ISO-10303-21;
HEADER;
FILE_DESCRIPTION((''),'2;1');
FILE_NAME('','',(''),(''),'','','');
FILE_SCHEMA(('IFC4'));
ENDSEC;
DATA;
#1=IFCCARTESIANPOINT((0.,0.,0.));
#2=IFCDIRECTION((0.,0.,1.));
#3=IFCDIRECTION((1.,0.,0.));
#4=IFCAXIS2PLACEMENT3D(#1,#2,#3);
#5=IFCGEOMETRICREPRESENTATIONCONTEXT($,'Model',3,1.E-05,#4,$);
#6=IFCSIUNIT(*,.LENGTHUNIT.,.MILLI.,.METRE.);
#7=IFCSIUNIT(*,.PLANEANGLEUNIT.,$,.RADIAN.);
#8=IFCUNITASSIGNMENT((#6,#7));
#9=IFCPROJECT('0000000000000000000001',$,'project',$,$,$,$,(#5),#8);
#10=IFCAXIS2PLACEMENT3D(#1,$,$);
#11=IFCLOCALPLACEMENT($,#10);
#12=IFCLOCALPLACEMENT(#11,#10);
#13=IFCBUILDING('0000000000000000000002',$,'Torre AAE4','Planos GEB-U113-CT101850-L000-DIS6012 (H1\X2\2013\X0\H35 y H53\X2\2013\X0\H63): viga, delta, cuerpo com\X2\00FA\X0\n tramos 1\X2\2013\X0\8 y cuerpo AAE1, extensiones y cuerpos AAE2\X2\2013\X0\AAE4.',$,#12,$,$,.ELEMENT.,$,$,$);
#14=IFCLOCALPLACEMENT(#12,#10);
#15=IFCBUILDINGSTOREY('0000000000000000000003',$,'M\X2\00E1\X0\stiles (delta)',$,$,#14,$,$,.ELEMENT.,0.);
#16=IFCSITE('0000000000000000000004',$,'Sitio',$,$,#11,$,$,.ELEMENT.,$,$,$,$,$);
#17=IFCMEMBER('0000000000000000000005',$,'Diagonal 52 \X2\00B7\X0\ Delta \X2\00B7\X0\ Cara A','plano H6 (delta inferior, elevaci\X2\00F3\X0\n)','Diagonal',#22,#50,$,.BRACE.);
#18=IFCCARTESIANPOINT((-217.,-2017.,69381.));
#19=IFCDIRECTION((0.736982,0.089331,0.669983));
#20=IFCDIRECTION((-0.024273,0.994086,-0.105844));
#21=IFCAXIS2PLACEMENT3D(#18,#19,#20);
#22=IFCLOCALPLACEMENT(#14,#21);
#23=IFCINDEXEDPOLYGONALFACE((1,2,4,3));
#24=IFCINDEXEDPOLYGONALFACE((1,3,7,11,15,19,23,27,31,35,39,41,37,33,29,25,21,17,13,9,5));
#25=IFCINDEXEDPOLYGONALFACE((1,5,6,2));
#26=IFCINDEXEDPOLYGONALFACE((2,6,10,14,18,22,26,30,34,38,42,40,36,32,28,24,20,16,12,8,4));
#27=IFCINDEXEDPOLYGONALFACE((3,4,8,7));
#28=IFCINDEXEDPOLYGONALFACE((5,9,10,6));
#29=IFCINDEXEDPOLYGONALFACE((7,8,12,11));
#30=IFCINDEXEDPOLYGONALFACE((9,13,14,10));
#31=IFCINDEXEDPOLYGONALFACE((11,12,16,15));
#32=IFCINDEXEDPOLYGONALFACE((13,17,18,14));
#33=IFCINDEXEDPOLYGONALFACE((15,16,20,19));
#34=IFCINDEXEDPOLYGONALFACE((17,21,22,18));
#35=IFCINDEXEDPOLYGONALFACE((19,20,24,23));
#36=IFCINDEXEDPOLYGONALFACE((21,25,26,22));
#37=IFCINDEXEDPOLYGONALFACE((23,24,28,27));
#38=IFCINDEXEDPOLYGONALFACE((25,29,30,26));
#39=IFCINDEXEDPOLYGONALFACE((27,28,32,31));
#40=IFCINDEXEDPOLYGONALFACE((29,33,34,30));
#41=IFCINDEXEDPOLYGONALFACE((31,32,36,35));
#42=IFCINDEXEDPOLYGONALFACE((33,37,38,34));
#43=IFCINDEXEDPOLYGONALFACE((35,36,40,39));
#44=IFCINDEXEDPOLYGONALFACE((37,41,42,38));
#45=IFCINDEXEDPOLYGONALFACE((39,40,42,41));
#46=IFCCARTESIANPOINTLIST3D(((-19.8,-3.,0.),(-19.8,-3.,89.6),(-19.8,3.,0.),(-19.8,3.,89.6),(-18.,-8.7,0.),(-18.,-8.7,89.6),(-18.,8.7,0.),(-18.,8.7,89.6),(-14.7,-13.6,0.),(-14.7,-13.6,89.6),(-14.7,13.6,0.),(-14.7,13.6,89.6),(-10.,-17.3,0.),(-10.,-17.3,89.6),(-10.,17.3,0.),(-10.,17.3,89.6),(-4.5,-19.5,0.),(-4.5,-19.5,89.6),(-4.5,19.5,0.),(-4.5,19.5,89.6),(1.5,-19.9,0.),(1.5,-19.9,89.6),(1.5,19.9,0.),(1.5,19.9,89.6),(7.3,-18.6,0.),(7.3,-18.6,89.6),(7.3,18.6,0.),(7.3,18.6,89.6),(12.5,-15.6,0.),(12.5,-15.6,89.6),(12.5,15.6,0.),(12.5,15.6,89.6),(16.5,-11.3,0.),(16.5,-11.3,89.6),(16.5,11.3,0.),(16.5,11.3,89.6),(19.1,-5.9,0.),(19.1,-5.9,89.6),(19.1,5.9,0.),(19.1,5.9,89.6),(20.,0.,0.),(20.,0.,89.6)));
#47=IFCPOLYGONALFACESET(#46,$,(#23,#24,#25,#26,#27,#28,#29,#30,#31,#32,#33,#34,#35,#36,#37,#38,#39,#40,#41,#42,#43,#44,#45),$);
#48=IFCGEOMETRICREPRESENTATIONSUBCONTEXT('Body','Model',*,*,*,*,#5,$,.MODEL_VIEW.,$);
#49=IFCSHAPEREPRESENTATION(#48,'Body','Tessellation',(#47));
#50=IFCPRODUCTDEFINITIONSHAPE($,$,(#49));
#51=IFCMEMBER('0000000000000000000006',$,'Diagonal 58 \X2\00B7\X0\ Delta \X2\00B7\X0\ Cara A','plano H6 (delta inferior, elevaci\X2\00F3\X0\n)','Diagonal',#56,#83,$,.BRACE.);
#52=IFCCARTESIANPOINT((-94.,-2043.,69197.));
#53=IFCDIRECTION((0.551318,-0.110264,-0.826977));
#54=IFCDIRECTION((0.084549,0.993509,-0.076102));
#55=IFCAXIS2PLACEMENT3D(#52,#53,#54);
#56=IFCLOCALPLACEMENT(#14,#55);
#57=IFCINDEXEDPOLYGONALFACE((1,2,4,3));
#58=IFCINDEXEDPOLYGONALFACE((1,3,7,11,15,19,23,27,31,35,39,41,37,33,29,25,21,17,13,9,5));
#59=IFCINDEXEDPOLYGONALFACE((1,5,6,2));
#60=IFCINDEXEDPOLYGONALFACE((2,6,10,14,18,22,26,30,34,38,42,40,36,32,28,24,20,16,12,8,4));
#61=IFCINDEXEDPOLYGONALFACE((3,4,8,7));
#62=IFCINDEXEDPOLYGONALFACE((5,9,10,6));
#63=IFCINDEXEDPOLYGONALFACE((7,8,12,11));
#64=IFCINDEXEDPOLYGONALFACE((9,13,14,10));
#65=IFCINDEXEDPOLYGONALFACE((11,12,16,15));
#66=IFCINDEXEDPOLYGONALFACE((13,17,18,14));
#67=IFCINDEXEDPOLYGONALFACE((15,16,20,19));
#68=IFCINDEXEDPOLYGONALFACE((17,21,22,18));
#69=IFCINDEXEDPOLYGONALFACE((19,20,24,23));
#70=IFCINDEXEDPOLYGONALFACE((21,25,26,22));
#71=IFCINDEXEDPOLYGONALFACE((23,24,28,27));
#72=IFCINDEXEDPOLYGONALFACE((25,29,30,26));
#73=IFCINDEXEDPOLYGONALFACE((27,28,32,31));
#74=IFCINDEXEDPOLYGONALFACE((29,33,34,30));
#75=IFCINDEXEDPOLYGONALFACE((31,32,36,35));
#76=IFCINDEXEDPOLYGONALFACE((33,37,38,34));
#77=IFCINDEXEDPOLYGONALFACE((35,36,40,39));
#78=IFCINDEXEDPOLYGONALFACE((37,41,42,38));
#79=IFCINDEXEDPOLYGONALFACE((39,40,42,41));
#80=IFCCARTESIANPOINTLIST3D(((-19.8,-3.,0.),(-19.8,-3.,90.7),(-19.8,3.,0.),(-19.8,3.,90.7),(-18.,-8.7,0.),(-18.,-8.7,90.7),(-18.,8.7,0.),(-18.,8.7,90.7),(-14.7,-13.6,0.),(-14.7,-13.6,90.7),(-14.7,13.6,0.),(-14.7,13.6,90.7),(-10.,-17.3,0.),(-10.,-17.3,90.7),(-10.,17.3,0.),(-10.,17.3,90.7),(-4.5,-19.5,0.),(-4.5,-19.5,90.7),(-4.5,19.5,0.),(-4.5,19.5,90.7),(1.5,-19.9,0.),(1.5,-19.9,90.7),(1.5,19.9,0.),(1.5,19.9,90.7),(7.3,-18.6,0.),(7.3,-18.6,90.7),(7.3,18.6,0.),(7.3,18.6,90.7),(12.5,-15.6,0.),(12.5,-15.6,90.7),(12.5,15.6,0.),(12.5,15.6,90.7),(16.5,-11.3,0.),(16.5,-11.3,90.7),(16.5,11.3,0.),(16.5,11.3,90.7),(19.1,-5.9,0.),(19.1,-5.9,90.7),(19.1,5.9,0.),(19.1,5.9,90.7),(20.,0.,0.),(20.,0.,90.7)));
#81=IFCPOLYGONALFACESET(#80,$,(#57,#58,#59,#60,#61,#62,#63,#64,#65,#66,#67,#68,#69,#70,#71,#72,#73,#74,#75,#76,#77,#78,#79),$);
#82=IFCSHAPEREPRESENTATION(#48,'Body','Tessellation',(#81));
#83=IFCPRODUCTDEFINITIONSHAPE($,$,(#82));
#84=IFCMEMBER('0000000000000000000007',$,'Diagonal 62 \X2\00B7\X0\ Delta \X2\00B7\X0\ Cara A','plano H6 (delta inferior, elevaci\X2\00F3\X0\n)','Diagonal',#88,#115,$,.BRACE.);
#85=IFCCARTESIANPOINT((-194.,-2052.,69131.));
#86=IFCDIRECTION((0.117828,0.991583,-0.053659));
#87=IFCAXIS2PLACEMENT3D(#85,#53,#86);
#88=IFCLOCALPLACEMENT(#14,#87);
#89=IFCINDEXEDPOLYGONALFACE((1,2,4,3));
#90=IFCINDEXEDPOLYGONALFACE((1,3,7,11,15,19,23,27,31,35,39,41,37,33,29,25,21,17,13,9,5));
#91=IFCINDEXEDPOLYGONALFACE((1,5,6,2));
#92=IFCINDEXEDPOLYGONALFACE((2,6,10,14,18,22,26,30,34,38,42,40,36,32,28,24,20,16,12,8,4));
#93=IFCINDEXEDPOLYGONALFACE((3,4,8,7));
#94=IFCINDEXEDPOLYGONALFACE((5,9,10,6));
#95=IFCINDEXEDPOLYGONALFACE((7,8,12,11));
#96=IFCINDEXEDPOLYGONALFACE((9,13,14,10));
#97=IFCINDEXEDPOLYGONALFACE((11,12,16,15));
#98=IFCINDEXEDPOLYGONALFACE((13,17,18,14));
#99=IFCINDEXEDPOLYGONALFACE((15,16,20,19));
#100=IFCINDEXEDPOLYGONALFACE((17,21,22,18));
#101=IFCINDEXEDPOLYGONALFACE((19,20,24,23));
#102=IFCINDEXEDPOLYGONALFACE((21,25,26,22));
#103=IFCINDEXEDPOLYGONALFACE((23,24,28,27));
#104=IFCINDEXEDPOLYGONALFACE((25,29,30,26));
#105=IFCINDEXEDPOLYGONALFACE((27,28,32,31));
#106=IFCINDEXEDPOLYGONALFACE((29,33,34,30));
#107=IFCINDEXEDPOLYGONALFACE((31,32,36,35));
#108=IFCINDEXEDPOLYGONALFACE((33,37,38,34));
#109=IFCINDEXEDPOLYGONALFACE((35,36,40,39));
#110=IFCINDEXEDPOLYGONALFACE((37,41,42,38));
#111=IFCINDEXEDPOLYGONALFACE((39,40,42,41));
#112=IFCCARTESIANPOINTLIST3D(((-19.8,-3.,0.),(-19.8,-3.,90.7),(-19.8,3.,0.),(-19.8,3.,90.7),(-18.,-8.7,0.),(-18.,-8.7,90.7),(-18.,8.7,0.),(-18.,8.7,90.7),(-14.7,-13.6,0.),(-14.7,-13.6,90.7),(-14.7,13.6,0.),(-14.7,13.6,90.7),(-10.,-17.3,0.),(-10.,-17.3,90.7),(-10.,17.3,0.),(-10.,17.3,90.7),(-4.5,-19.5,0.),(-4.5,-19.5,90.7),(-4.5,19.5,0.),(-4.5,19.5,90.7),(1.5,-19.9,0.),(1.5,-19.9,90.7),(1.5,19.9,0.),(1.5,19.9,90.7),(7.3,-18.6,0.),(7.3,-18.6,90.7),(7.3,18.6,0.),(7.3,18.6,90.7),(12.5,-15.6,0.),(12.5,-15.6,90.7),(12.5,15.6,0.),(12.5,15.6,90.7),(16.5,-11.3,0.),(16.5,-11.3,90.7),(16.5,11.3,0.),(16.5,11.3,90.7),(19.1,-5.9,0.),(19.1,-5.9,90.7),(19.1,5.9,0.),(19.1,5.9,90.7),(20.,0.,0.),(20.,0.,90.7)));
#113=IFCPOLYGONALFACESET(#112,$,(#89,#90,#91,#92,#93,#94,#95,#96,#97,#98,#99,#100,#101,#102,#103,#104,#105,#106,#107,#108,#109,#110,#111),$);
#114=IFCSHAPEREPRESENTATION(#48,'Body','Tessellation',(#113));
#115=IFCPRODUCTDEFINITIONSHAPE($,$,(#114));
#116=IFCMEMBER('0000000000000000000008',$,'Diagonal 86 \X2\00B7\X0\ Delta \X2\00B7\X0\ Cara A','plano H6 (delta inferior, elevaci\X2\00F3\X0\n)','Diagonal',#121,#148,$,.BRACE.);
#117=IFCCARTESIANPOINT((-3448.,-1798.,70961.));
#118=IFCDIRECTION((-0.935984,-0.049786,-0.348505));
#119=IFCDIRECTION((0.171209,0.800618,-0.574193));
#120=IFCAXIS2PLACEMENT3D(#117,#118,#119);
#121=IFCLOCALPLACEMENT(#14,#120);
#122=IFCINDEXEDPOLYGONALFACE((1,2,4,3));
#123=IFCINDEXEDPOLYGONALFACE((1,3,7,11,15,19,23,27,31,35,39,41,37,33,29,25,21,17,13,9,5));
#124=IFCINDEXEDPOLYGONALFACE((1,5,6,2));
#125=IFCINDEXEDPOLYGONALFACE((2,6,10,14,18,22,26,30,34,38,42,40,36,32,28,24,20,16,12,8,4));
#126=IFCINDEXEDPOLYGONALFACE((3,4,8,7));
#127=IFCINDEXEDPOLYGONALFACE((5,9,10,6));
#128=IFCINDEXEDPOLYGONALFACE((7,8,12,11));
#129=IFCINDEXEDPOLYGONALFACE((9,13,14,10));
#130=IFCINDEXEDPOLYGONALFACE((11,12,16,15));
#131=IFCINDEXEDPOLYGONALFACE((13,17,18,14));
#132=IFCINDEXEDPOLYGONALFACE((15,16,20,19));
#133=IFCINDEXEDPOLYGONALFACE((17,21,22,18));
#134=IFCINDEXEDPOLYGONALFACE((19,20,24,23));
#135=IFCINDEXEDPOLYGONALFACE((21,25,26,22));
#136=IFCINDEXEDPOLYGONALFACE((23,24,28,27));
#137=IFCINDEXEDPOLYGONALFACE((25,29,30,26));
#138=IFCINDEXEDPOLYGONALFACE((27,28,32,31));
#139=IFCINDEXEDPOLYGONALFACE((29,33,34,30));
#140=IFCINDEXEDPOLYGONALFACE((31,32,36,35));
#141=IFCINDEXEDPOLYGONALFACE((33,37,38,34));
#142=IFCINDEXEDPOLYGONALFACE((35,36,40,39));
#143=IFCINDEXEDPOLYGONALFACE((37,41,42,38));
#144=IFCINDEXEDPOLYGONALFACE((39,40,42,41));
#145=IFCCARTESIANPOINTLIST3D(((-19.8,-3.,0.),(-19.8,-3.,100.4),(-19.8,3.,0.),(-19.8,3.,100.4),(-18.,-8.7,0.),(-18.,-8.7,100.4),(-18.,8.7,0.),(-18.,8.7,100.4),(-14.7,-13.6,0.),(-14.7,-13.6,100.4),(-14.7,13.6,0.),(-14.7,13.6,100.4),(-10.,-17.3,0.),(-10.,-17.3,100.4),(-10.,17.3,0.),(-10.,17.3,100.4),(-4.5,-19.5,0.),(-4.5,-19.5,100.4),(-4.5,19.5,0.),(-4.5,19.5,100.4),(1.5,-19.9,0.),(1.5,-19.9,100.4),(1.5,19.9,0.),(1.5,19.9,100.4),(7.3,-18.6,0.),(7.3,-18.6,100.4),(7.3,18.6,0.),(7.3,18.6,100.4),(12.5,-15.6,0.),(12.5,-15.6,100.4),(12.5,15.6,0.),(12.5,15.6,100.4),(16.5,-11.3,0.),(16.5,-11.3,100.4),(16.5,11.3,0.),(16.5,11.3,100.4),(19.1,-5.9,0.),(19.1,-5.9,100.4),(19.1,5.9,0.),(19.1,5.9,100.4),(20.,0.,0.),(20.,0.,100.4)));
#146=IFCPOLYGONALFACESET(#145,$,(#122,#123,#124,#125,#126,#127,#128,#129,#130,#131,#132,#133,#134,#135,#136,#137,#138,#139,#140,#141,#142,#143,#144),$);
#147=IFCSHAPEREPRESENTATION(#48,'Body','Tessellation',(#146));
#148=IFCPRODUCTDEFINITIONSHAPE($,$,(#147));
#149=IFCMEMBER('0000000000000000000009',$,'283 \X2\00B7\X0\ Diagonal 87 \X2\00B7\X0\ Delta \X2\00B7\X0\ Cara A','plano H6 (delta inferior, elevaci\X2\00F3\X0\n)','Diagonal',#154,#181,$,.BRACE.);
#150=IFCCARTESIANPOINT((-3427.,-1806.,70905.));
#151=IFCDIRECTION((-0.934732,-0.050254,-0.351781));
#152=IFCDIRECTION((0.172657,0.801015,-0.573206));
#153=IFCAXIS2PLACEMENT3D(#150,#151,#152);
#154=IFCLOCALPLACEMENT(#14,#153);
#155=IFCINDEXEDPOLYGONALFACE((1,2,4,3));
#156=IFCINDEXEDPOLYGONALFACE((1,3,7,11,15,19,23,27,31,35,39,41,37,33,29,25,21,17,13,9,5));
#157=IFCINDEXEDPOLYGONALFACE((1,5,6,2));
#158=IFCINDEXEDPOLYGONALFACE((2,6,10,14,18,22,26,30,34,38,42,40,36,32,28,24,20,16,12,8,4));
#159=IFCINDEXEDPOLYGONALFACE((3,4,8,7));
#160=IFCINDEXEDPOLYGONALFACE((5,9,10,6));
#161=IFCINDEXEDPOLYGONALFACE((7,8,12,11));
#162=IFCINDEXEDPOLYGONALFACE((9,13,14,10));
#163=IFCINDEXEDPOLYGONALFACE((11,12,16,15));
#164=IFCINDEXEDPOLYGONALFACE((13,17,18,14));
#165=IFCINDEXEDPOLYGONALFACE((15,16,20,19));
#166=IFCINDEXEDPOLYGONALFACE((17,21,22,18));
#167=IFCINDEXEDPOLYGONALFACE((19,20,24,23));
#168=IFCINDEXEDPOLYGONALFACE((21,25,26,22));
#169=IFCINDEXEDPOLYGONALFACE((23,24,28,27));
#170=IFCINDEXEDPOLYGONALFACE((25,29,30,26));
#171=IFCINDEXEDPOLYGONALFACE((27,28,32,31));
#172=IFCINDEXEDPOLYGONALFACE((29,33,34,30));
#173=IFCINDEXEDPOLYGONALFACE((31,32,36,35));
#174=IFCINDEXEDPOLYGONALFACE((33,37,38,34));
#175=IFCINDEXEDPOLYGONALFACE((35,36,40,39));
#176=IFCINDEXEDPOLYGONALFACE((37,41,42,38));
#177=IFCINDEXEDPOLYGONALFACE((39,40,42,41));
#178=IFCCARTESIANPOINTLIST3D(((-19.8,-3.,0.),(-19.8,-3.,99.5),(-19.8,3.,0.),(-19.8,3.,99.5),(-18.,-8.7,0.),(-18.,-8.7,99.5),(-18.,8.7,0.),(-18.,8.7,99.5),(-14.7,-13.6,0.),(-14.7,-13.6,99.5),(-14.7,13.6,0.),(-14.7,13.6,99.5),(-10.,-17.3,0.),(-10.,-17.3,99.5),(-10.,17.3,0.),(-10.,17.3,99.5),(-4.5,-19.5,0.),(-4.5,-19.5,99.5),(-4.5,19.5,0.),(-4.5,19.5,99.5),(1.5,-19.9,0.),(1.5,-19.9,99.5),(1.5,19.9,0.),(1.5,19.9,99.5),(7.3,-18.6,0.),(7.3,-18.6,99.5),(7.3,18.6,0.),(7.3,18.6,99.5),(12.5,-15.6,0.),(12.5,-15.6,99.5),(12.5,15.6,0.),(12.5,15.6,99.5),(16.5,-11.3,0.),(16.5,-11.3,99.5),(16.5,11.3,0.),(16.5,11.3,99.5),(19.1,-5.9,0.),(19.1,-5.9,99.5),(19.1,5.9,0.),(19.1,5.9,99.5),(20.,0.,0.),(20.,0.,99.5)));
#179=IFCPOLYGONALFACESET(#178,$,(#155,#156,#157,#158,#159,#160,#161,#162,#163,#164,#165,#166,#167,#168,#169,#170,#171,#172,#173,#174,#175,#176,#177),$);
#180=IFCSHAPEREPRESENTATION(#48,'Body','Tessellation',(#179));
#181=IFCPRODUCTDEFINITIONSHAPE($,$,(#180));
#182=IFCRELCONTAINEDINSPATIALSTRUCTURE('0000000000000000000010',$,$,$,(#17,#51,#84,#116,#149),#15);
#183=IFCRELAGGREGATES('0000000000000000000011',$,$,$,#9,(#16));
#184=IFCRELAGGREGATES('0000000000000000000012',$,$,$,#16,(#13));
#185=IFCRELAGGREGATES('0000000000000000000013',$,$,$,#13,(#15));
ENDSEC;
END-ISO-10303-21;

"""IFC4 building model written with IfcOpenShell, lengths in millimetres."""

from ifc_helpers import new_model, si_unit, frame, origin, origin_with_axes, place, context, subcontext, project, spatial, circle, extrude, element, save


model = new_model("IFC4")

# Units and contexts
model_context = context("Model", 3, precision=1e-05, world=origin_with_axes())
body_context = subcontext(model_context, "Body", "Model", "MODEL_VIEW")
ifc_project = project(units=[si_unit("LENGTHUNIT", "METRE", prefix="MILLI"), si_unit("PLANEANGLEUNIT", "RADIAN")], contexts=[model_context])

# Site, building, storey
site_placement = place(None, origin())
site = spatial("IfcSite", under=ifc_project, at=site_placement, Name="Sitio", CompositionType="ELEMENT")
building_placement = place(site_placement, origin())
building = spatial("IfcBuilding", under=site, at=building_placement, Name="Torre AAE4", Description="Planos GEB-U113-CT101850-L000-DIS6012 (H1–H35 y H53–H63): viga, delta, cuerpo común tramos 1–8 y cuerpo AAE1, extensiones y cuerpos AAE2–AAE4.", CompositionType="ELEMENT")
storey_placement = place(building_placement, origin())
storey = spatial("IfcBuildingStorey", under=building, at=storey_placement, Name="Mástiles (delta)", CompositionType="ELEMENT", Elevation=0.0)

# Members
member_1_placement = place(storey_placement, frame((-217.0, -2017.0, 69381.0), z_axis=(0.736982, 0.089331, 0.669983), x_axis=(-0.024273, 0.994086, -0.105844)))
element("IfcMember", 1, at=member_1_placement, inside=storey, Name="Diagonal 52 · Delta · Cara A", Description="plano H6 (delta inferior, elevación)", ObjectType="Diagonal", PredefinedType="BRACE", context=body_context, shape_type="SweptSolid", body=[
    extrude(circle(Radius=20.0), None, (0.0, 0.0, 1.0), 89.6),
])
member_2_placement = place(storey_placement, frame((-94.0, -2043.0, 69197.0), z_axis=(0.551318, -0.110264, -0.826977), x_axis=(0.084549, 0.993509, -0.076102)))
element("IfcMember", 2, at=member_2_placement, inside=storey, Name="Diagonal 58 · Delta · Cara A", Description="plano H6 (delta inferior, elevación)", ObjectType="Diagonal", PredefinedType="BRACE", context=body_context, shape_type="SweptSolid", body=[
    extrude(circle(Radius=20.0), None, (0.0, 0.0, 1.0), 90.7),
])
member_3_placement = place(storey_placement, frame((-194.0, -2052.0, 69131.0), z_axis=(0.551318, -0.110264, -0.826977), x_axis=(0.117828, 0.991583, -0.053659)))
element("IfcMember", 3, at=member_3_placement, inside=storey, Name="Diagonal 62 · Delta · Cara A", Description="plano H6 (delta inferior, elevación)", ObjectType="Diagonal", PredefinedType="BRACE", context=body_context, shape_type="SweptSolid", body=[
    extrude(circle(Radius=20.0), None, (0.0, 0.0, 1.0), 90.7),
])
member_4_placement = place(storey_placement, frame((-3448.0, -1798.0, 70961.0), z_axis=(-0.935984, -0.049786, -0.348505), x_axis=(0.171209, 0.800618, -0.574193)))
element("IfcMember", 4, at=member_4_placement, inside=storey, Name="Diagonal 86 · Delta · Cara A", Description="plano H6 (delta inferior, elevación)", ObjectType="Diagonal", PredefinedType="BRACE", context=body_context, shape_type="SweptSolid", body=[
    extrude(circle(Radius=20.0), None, (0.0, 0.0, 1.0), 100.4),
])
member_5_placement = place(storey_placement, frame((-3427.0, -1806.0, 70905.0), z_axis=(-0.934732, -0.050254, -0.351781), x_axis=(0.172657, 0.801015, -0.573206)))
element("IfcMember", 5, at=member_5_placement, inside=storey, Name="283 · Diagonal 87 · Delta · Cara A", Description="plano H6 (delta inferior, elevación)", ObjectType="Diagonal", PredefinedType="BRACE", context=body_context, shape_type="SweptSolid", body=[
    extrude(circle(Radius=20.0), None, (0.0, 0.0, 1.0), 99.5),
])

save(model, "model.ifc")
